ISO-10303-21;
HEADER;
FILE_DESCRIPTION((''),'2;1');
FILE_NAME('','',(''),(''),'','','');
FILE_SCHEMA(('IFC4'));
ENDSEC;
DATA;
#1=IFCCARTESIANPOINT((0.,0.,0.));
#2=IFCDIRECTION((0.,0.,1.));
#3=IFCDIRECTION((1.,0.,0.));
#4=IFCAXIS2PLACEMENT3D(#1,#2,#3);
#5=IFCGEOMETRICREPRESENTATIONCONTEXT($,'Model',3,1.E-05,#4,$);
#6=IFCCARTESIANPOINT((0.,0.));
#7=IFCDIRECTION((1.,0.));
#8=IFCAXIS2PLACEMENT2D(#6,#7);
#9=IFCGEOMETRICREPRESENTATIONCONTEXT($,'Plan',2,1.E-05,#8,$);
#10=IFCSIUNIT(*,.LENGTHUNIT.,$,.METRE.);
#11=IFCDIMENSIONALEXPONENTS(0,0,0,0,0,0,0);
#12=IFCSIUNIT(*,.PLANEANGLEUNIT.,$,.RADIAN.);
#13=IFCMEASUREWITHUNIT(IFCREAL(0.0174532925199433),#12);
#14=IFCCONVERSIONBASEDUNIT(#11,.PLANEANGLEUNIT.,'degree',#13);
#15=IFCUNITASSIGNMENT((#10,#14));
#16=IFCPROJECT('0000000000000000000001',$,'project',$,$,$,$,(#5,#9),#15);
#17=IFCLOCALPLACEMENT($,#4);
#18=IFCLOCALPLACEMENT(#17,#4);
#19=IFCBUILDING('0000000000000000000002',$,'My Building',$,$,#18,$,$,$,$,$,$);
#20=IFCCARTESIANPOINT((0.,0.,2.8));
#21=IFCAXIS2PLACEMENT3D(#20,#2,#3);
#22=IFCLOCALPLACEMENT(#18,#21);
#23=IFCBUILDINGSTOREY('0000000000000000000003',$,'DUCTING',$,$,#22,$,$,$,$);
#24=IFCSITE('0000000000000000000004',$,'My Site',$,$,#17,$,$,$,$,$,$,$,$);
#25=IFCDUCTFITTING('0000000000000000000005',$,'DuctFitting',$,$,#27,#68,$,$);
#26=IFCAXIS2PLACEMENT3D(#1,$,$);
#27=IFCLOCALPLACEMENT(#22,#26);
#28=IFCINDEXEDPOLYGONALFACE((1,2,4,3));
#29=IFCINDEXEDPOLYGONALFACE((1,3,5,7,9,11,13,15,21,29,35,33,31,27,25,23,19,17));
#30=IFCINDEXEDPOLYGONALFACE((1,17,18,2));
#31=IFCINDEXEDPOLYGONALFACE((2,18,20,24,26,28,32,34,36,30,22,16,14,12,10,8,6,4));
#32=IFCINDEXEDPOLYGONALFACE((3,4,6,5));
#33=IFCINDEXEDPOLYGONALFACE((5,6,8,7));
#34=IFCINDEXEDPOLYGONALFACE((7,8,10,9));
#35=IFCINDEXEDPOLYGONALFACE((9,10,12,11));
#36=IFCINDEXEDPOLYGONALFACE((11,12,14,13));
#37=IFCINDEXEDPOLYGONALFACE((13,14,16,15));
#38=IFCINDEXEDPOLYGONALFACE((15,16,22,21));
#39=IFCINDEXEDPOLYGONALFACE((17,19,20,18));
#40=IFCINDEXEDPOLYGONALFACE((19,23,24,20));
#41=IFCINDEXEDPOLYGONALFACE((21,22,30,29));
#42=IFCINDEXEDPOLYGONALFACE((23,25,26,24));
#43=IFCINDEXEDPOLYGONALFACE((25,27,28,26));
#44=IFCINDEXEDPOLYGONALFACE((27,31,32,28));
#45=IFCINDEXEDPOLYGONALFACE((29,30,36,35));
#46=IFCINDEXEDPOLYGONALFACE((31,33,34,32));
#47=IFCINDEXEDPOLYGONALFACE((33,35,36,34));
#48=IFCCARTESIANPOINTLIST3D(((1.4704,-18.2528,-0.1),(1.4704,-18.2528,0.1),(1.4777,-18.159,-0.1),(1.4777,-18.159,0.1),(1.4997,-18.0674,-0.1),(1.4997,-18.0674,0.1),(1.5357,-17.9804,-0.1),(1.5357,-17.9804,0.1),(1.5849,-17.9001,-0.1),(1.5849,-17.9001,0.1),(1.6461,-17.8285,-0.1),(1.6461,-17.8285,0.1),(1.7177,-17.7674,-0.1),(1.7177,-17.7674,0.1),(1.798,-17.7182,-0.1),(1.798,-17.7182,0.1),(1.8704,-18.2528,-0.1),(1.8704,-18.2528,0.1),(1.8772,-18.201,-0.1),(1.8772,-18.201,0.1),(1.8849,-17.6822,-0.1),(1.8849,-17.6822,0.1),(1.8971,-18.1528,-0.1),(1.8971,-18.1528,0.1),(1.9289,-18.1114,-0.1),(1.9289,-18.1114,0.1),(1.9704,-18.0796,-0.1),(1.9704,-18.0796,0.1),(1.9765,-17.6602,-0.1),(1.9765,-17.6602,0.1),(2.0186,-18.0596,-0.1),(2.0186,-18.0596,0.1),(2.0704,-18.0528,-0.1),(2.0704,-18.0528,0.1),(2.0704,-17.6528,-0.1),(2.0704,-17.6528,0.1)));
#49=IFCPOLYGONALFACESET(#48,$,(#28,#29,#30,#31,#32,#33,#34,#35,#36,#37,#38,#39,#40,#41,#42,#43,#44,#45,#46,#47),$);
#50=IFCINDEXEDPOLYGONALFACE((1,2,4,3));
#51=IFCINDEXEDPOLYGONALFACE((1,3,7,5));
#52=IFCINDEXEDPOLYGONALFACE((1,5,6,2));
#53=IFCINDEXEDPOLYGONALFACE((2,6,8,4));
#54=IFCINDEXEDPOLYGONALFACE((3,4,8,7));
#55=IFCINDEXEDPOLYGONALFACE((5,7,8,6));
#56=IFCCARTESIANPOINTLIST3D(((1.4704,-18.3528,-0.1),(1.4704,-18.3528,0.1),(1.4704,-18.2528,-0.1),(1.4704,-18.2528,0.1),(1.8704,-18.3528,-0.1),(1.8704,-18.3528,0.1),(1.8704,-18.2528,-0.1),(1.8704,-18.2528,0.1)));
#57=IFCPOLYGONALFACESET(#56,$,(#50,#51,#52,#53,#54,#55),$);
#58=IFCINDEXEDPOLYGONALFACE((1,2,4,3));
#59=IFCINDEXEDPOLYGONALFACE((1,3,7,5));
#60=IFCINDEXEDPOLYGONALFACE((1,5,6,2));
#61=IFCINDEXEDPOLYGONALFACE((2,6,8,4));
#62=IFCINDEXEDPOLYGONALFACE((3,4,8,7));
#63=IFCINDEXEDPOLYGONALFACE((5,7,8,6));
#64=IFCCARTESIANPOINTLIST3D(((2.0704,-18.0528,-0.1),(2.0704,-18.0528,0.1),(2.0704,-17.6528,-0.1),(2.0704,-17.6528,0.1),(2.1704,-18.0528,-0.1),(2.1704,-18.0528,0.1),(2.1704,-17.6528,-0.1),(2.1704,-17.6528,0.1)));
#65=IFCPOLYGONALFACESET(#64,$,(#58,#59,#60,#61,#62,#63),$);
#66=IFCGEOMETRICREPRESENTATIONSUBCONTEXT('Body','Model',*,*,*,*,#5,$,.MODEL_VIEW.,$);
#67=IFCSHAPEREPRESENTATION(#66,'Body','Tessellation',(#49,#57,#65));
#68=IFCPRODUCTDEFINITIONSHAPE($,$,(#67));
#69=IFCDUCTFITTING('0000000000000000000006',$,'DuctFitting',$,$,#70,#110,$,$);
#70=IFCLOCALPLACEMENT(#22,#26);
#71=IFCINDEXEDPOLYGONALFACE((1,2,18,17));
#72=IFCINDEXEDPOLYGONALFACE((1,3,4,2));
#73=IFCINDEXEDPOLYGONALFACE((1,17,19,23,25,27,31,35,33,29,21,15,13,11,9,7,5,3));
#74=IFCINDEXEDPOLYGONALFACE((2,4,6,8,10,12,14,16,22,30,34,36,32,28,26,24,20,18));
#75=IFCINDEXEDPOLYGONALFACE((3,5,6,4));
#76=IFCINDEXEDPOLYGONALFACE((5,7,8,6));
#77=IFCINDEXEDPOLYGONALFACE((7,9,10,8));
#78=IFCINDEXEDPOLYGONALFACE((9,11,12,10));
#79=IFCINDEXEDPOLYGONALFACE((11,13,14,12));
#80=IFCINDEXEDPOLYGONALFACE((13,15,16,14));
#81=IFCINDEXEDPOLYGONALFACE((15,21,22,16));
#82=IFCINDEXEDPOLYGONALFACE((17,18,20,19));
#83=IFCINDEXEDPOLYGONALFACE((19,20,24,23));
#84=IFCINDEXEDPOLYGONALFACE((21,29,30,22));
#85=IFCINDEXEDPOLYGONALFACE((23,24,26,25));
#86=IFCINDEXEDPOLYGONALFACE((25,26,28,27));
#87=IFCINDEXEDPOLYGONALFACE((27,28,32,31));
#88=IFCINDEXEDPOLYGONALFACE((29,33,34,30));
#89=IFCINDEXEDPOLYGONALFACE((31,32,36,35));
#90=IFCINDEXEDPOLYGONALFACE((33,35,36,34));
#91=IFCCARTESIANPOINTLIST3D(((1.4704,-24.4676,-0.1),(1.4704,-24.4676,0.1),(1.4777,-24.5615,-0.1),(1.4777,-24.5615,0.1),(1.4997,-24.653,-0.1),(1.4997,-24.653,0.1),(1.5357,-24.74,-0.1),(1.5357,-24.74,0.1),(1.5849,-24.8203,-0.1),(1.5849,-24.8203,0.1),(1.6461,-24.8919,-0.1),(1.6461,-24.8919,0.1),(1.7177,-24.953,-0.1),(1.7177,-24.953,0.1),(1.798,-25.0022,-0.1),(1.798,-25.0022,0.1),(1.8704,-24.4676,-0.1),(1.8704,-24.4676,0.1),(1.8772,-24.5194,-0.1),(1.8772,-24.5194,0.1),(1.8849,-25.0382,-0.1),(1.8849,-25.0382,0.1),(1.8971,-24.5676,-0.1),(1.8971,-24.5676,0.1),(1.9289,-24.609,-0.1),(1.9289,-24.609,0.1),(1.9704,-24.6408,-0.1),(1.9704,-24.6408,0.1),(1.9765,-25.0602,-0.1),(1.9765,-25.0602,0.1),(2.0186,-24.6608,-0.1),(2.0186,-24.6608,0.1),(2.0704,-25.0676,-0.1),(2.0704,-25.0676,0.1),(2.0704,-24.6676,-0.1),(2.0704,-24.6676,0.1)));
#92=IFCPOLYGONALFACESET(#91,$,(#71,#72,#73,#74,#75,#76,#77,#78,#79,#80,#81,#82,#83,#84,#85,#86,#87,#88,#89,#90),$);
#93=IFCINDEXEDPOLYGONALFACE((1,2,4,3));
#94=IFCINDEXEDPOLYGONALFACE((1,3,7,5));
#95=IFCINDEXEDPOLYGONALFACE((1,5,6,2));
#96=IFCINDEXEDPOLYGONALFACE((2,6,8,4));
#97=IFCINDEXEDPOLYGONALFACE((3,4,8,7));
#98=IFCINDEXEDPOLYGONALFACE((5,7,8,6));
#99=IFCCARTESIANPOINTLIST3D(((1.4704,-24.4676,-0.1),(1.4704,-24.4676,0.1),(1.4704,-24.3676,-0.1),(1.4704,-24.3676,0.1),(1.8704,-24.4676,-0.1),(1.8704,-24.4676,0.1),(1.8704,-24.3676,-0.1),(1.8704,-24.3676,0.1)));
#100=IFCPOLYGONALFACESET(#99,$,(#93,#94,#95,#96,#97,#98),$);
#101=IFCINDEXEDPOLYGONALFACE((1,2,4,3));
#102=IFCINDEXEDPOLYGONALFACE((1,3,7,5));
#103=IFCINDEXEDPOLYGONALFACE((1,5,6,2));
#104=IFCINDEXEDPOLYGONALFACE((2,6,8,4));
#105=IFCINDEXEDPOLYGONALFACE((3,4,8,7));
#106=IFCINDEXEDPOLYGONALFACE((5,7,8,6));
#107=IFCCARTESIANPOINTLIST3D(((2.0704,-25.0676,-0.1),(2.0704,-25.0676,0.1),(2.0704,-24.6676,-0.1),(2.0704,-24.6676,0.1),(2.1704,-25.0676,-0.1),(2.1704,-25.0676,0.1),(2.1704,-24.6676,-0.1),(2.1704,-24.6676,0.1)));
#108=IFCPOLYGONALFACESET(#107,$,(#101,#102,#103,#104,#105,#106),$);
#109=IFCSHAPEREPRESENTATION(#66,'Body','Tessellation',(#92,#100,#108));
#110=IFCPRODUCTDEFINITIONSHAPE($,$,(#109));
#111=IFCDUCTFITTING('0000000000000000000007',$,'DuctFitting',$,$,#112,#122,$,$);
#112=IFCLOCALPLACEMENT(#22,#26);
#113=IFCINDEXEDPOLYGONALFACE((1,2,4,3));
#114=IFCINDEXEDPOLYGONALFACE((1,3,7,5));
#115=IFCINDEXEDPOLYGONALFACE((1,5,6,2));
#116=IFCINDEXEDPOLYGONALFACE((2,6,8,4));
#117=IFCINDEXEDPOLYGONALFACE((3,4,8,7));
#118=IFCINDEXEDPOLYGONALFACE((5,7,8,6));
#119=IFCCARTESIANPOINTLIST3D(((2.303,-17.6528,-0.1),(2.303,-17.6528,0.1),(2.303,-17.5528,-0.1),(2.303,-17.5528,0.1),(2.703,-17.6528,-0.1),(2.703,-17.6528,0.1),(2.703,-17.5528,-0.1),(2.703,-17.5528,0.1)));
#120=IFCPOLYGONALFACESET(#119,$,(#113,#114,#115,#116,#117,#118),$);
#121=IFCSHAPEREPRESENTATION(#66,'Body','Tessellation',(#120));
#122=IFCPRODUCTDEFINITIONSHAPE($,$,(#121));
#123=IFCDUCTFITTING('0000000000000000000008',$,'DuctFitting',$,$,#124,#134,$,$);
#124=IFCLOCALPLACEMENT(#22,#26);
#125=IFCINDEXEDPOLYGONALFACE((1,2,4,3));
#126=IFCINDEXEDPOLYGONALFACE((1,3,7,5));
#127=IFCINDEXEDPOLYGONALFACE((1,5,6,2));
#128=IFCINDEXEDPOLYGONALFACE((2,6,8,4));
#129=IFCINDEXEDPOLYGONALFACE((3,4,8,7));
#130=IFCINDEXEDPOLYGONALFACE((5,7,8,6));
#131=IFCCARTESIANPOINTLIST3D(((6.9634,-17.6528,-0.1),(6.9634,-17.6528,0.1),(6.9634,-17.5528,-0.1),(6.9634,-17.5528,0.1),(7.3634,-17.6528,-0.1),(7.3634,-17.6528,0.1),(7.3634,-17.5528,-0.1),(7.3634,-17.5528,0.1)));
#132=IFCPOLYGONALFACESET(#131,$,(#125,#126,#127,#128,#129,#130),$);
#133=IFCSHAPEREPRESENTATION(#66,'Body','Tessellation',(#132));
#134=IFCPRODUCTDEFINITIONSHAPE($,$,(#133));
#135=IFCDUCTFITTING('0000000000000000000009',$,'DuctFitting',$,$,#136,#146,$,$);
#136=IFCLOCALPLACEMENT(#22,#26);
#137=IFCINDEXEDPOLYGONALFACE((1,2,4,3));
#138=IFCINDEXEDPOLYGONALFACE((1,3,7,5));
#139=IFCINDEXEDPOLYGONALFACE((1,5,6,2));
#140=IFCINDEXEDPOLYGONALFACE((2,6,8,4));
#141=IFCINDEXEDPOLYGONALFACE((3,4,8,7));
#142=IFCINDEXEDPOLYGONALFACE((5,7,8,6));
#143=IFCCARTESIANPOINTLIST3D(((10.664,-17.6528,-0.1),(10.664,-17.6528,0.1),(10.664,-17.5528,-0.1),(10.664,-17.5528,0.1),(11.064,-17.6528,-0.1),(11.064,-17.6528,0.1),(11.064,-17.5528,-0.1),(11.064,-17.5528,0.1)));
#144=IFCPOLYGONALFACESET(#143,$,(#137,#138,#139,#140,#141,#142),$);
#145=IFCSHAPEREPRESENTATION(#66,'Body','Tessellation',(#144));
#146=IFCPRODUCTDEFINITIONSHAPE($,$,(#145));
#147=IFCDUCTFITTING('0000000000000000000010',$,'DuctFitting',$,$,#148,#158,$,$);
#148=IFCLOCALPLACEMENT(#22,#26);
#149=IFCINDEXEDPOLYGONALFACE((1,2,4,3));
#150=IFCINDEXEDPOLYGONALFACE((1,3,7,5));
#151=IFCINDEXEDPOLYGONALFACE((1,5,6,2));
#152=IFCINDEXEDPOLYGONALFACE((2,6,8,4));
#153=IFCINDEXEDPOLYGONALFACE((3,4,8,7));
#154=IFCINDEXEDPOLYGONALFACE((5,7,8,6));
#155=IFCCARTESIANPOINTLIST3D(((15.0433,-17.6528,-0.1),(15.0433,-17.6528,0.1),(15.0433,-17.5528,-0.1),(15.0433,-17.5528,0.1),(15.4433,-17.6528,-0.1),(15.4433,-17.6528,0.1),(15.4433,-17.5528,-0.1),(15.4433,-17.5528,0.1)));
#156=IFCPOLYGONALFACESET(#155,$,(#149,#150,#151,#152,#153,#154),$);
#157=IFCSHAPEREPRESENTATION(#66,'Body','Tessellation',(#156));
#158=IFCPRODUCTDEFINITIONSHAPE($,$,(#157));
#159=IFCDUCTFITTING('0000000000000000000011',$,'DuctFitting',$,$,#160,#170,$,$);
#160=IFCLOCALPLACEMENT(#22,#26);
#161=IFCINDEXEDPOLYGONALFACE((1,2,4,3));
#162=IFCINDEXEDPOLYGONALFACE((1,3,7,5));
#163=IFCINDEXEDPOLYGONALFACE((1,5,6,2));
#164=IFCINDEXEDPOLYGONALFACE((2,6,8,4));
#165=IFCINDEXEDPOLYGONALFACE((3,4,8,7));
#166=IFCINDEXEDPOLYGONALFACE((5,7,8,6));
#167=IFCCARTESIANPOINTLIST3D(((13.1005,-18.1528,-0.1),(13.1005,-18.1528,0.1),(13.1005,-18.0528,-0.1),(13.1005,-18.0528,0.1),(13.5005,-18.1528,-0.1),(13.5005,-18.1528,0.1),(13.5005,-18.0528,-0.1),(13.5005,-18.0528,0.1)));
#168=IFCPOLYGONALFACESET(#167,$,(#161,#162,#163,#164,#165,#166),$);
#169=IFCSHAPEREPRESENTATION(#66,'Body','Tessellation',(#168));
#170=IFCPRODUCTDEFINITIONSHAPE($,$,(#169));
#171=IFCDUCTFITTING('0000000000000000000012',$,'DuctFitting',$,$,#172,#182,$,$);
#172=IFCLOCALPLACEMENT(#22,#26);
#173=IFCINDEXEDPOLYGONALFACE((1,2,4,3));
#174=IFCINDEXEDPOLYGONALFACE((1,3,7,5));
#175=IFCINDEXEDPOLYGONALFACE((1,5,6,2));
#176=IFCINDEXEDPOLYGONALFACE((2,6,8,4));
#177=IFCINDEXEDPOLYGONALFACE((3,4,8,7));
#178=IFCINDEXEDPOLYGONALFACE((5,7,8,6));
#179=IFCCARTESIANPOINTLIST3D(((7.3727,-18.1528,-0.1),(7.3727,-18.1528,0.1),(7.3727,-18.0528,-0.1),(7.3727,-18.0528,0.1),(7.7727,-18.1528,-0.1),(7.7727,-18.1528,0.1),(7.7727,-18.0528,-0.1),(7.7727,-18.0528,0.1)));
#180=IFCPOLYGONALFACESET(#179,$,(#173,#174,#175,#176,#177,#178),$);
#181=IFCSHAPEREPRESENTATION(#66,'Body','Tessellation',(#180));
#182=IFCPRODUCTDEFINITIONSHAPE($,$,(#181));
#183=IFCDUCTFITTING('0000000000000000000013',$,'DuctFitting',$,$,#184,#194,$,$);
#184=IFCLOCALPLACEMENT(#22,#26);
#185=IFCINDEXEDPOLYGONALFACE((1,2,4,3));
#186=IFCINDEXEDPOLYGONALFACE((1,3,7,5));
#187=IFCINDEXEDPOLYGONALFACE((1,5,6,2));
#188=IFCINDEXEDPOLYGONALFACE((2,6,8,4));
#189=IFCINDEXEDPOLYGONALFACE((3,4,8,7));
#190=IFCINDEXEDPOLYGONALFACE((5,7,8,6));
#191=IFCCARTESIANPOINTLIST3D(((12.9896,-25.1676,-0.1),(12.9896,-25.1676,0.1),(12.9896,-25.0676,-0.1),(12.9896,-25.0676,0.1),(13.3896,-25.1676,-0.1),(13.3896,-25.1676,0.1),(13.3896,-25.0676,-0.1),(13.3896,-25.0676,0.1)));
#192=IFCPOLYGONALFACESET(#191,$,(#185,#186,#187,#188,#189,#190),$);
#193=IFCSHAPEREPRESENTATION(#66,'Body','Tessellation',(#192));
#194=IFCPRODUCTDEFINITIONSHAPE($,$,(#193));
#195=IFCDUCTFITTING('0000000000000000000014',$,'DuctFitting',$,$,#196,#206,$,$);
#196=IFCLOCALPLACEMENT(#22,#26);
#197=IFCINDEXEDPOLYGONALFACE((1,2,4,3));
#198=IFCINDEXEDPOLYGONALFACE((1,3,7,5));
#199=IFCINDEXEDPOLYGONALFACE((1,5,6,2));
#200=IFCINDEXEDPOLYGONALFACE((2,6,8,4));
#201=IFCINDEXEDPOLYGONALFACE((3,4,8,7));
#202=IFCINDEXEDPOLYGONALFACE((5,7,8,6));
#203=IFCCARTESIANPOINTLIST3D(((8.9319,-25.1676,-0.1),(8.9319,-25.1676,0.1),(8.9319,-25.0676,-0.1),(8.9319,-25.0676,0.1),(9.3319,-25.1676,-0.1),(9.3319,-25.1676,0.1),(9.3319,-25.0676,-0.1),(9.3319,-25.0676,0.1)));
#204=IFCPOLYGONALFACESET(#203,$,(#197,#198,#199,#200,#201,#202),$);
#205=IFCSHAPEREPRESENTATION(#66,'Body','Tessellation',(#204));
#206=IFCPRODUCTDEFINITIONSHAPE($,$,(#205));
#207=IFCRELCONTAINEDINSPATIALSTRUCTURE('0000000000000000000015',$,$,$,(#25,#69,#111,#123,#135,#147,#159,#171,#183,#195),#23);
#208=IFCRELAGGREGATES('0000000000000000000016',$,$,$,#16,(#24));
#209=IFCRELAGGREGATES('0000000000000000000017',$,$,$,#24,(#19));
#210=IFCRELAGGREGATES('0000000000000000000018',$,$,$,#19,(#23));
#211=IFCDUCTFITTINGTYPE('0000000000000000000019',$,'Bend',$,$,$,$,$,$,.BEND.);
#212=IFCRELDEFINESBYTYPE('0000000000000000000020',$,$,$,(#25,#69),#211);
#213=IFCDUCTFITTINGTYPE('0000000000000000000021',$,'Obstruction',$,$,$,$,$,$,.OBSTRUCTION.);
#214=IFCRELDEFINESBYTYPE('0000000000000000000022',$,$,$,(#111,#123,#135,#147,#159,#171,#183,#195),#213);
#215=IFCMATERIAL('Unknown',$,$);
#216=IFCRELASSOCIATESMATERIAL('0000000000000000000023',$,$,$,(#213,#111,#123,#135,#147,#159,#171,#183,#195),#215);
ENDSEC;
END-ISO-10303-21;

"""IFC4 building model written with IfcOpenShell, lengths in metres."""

from ifc_helpers import new_model, entity, si_unit, converted_unit, frame, origin_with_axes, origin_2d_with_axis, place, context, subcontext, project, spatial, line, arc, indexed_curve, rectangle, outline, extrude, source, transform, mapped, material, material_profile, profile_set, profile_usage, type_object, type_shapes, element, save


model = new_model("IFC4")

# Units and contexts
model_context = context("Model", 3, precision=1e-05, world=origin_with_axes())
plan_context = context("Plan", 2, precision=1e-05, world=origin_2d_with_axis())
body_context = subcontext(model_context, "Body", "Model", "MODEL_VIEW")
ifc_project = project(units=[si_unit("LENGTHUNIT", "METRE"), converted_unit("PLANEANGLEUNIT", "degree", entity("IfcReal", 0.0174532925199433), si_unit("PLANEANGLEUNIT", "RADIAN"), dimensions=[0, 0, 0, 0, 0, 0, 0])], contexts=[model_context, plan_context])

# Site, building, storey
site_placement = place(None, origin_with_axes())
site = spatial("IfcSite", under=ifc_project, at=site_placement, Name="My Site")
building_placement = place(site_placement, origin_with_axes())
building = spatial("IfcBuilding", under=site, at=building_placement, Name="My Building")
storey_placement = place(building_placement, frame((0.0, 0.0, 2.8), z_axis=(0.0, 0.0, 1.0), x_axis=(1.0, 0.0, 0.0)))
storey = spatial("IfcBuildingStorey", under=building, at=storey_placement, Name="DUCTING")

# Shared definitions
ifc_material = material(Name="Unknown")

# Duct fittings
duct_fitting_type_1 = type_object("IfcDuctFittingType", Name="Bend", PredefinedType="BEND")
shared_shape = source(origin_with_axes(), body_context, "Body", "SweptSolid", [
    extrude(outline(indexed_curve([(-0.2, 0.0), (-0.2586, -0.1414), (-0.4, -0.2), (-0.4, -0.6), (0.0243, -0.4243), (0.2, 0.0)], segments=[arc(1, 2, 3), line(3, 4), arc(4, 5, 6), line(6, 1)])), frame((0.0, -0.1, -0.1), z_axis=(0.0, -1.0, 0.0), x_axis=(1.0, 0.0, 0.0)), (0.0, 0.0, -1.0), 0.2),
    extrude(rectangle(XDim=0.4, YDim=0.2), origin_with_axes(), (0.0, 0.0, -1.0), 0.1),
    extrude(rectangle(XDim=0.4, YDim=0.2), frame((-0.4, 0.0, -0.5), z_axis=(-1.0, 0.0, -0.000001), x_axis=(0.000001, 0.0, -1.0)), (0.0, 0.0, 1.0), 0.1),
])
type_shapes(duct_fitting_type_1, [shared_shape])
for number, where, z_axis, x_axis, name in (
    (1, (1.6704, -18.3528, 0.0), (0.0, -1.0, 0.0), (-1.0, 0.0, 0.0), "DuctFitting"),
    (2, (1.6704, -24.3676, 0.0), (0.0, 1.0, 0.0), (-1.0, 0.0, 0.0), "DuctFitting"),
):
    element("IfcDuctFitting", number, at=place(storey_placement, frame(where, z_axis=z_axis, x_axis=x_axis)), inside=storey, type_object=duct_fitting_type_1, Name=name, context=body_context, shape_type="MappedRepresentation", body=[
        mapped(shared_shape, transform((0.0, 0.0, 0.0), x_axis=(1.0, 0.0, 0.0), y_axis=(0.0, 1.0, 0.0), z_axis=(0.0, 0.0, 1.0), scale=1.0)),
    ])
ifc_material_profile_1 = material_profile(ifc_material, rectangle(XDim=0.4, YDim=0.2))
ifc_profile_set_1 = profile_set([ifc_material_profile_1])
ifc_profile_usage_1 = profile_usage(ifc_profile_set_1, cardinal=5)
duct_fitting_type_2 = type_object("IfcDuctFittingType", Name="Obstruction", PredefinedType="OBSTRUCTION", material=ifc_profile_set_1)
duct_fitting_1_placement = place(storey_placement, frame((2.503, -17.6528, 0.0), z_axis=(0.0, 1.0, 0.0), x_axis=(-1.0, 0.0, 0.0)))
element("IfcDuctFitting", 3, at=duct_fitting_1_placement, inside=storey, type_object=duct_fitting_type_2, material=ifc_profile_usage_1, Name="DuctFitting", context=body_context, shape_type="SweptSolid", body=[
    extrude(rectangle(XDim=0.4, YDim=0.2), origin_with_axes(), (0.0, 0.0, 1.0), 0.1),
])
ifc_profile_usage_2 = profile_usage(ifc_profile_set_1, cardinal=5)
duct_fitting_2_placement = place(storey_placement, frame((7.1634, -17.6528, 0.0), z_axis=(0.0, 1.0, 0.0), x_axis=(-1.0, 0.0, 0.0)))
element("IfcDuctFitting", 4, at=duct_fitting_2_placement, inside=storey, type_object=duct_fitting_type_2, material=ifc_profile_usage_2, Name="DuctFitting", context=body_context, shape_type="SweptSolid", body=[
    extrude(rectangle(XDim=0.4, YDim=0.2), origin_with_axes(), (0.0, 0.0, 1.0), 0.1),
])
ifc_profile_usage_3 = profile_usage(ifc_profile_set_1, cardinal=5)
duct_fitting_3_placement = place(storey_placement, frame((10.864, -17.6528, 0.0), z_axis=(0.0, 1.0, 0.0), x_axis=(-1.0, 0.0, 0.0)))
element("IfcDuctFitting", 5, at=duct_fitting_3_placement, inside=storey, type_object=duct_fitting_type_2, material=ifc_profile_usage_3, Name="DuctFitting", context=body_context, shape_type="SweptSolid", body=[
    extrude(rectangle(XDim=0.4, YDim=0.2), origin_with_axes(), (0.0, 0.0, 1.0), 0.1),
])
ifc_profile_usage_4 = profile_usage(ifc_profile_set_1, cardinal=5)
duct_fitting_4_placement = place(storey_placement, frame((15.2433, -17.6528, 0.0), z_axis=(0.0, 1.0, 0.0), x_axis=(-1.0, 0.0, 0.0)))
element("IfcDuctFitting", 6, at=duct_fitting_4_placement, inside=storey, type_object=duct_fitting_type_2, material=ifc_profile_usage_4, Name="DuctFitting", context=body_context, shape_type="SweptSolid", body=[
    extrude(rectangle(XDim=0.4, YDim=0.2), origin_with_axes(), (0.0, 0.0, 1.0), 0.1),
])
ifc_profile_usage_5 = profile_usage(ifc_profile_set_1, cardinal=5)
duct_fitting_5_placement = place(storey_placement, frame((13.3005, -18.0528, 0.0), z_axis=(0.0, -1.0, 0.0), x_axis=(1.0, 0.0, 0.0)))
element("IfcDuctFitting", 7, at=duct_fitting_5_placement, inside=storey, type_object=duct_fitting_type_2, material=ifc_profile_usage_5, Name="DuctFitting", context=body_context, shape_type="SweptSolid", body=[
    extrude(rectangle(XDim=0.4, YDim=0.2), origin_with_axes(), (0.0, 0.0, 1.0), 0.1),
])
ifc_profile_usage_6 = profile_usage(ifc_profile_set_1, cardinal=5)
duct_fitting_6_placement = place(storey_placement, frame((7.5727, -18.0528, 0.0), z_axis=(0.0, -1.0, 0.0), x_axis=(1.0, 0.0, 0.0)))
element("IfcDuctFitting", 8, at=duct_fitting_6_placement, inside=storey, type_object=duct_fitting_type_2, material=ifc_profile_usage_6, Name="DuctFitting", context=body_context, shape_type="SweptSolid", body=[
    extrude(rectangle(XDim=0.4, YDim=0.2), origin_with_axes(), (0.0, 0.0, 1.0), 0.1),
])
ifc_profile_usage_7 = profile_usage(ifc_profile_set_1, cardinal=5)
duct_fitting_7_placement = place(storey_placement, frame((13.1896, -25.0676, 0.0), z_axis=(0.0, -1.0, 0.0), x_axis=(1.0, 0.0, 0.0)))
element("IfcDuctFitting", 9, at=duct_fitting_7_placement, inside=storey, type_object=duct_fitting_type_2, material=ifc_profile_usage_7, Name="DuctFitting", context=body_context, shape_type="SweptSolid", body=[
    extrude(rectangle(XDim=0.4, YDim=0.2), origin_with_axes(), (0.0, 0.0, 1.0), 0.1),
])
ifc_profile_usage_8 = profile_usage(ifc_profile_set_1, cardinal=5)
duct_fitting_8_placement = place(storey_placement, frame((9.1319, -25.0676, 0.0), z_axis=(0.0, -1.0, 0.0), x_axis=(1.0, 0.0, 0.0)))
element("IfcDuctFitting", 10, at=duct_fitting_8_placement, inside=storey, type_object=duct_fitting_type_2, material=ifc_profile_usage_8, Name="DuctFitting", context=body_context, shape_type="SweptSolid", body=[
    extrude(rectangle(XDim=0.4, YDim=0.2), origin_with_axes(), (0.0, 0.0, 1.0), 0.1),
])

save(model, "model.ifc")
